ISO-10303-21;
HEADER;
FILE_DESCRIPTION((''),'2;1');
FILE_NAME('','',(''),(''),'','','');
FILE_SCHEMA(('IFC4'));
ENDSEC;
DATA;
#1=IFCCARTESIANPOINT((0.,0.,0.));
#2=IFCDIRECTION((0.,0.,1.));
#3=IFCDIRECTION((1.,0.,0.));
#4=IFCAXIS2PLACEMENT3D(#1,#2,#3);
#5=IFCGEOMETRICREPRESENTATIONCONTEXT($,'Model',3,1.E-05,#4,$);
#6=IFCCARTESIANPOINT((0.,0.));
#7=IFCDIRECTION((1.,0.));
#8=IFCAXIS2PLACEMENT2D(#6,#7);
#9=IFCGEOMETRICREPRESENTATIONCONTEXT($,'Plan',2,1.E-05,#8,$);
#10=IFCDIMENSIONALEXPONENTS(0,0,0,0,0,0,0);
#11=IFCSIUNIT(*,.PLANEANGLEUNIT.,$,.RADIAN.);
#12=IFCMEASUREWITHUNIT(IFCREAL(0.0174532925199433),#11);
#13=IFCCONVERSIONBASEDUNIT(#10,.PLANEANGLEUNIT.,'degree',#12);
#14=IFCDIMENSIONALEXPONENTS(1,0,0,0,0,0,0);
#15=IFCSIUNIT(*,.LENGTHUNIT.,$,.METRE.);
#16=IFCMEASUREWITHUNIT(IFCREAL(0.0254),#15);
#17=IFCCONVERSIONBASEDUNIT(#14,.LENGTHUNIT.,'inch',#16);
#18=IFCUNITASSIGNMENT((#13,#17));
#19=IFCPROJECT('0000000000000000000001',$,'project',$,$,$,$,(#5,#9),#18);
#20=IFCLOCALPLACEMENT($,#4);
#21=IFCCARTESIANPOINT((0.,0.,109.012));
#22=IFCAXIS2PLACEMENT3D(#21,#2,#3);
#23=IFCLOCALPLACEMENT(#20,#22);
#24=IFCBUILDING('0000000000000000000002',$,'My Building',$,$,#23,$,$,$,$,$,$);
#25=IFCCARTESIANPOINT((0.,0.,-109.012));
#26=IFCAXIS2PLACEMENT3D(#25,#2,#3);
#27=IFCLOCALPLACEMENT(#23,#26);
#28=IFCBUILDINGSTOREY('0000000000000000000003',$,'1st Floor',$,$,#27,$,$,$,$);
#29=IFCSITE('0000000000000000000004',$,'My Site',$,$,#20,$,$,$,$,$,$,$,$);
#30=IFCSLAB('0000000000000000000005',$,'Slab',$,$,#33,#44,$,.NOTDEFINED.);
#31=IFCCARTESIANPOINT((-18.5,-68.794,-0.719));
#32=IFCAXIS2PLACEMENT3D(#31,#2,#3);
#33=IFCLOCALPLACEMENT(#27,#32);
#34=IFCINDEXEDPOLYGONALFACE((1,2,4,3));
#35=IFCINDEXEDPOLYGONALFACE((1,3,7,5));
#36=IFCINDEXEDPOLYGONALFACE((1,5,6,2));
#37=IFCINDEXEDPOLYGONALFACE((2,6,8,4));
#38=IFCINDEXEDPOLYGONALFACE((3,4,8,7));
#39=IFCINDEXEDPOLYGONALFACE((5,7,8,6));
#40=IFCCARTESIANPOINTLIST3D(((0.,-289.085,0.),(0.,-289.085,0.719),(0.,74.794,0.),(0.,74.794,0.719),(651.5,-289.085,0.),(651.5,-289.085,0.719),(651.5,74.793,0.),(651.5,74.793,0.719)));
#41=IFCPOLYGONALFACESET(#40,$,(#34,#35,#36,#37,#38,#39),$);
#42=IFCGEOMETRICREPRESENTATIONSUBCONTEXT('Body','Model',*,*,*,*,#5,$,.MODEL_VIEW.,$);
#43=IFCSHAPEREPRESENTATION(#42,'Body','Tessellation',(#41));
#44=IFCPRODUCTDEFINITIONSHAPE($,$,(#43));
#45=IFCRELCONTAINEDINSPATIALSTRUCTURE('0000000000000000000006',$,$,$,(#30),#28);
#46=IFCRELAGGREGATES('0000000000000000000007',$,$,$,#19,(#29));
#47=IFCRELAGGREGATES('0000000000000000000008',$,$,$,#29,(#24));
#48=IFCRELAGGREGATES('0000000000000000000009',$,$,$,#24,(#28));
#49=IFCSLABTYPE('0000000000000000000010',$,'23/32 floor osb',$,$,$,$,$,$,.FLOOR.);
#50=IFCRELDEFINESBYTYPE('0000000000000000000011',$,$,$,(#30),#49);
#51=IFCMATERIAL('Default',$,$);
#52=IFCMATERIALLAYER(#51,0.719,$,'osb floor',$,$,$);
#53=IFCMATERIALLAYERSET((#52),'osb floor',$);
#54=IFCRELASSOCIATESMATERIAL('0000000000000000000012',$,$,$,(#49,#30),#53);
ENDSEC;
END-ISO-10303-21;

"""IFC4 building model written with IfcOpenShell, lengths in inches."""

from ifc_helpers import new_model, entity, si_unit, converted_unit, frame, origin_with_axes, origin_2d_with_axis, place, context, subcontext, project, spatial, line, indexed_curve, outline, extrude, material, layer, layer_set, layer_usage, type_object, element, save


model = new_model("IFC4")

# Units and contexts
model_context = context("Model", 3, precision=1e-05, world=origin_with_axes())
plan_context = context("Plan", 2, precision=1e-05, world=origin_2d_with_axis())
body_context = subcontext(model_context, "Body", "Model", "MODEL_VIEW")
ifc_project = project(units=[converted_unit("PLANEANGLEUNIT", "degree", entity("IfcReal", 0.0174532925199433), si_unit("PLANEANGLEUNIT", "RADIAN"), dimensions=[0, 0, 0, 0, 0, 0, 0]), converted_unit("LENGTHUNIT", "inch", entity("IfcReal", 0.0254), si_unit("LENGTHUNIT", "METRE"), dimensions=[1, 0, 0, 0, 0, 0, 0])], contexts=[model_context, plan_context])

# Site, building, storey
site_placement = place(None, origin_with_axes())
site = spatial("IfcSite", under=ifc_project, at=site_placement, Name="My Site")
building_placement = place(site_placement, frame((0.0, 0.0, 109.012), z_axis=(0.0, 0.0, 1.0), x_axis=(1.0, 0.0, 0.0)))
building = spatial("IfcBuilding", under=site, at=building_placement, Name="My Building")
storey_placement = place(building_placement, frame((0.0, 0.0, -109.012), z_axis=(0.0, 0.0, 1.0), x_axis=(1.0, 0.0, 0.0)))
storey = spatial("IfcBuildingStorey", under=building, at=storey_placement, Name="1st Floor")

# Shared definitions
ifc_material = material(Name="Default")

# Slab
ifc_layer_1 = layer(ifc_material, 0.719, Name="osb floor")
ifc_layer_set_1 = layer_set([ifc_layer_1], Name="osb floor")
ifc_layer_usage_1 = layer_usage(ifc_layer_set_1, "AXIS3", "POSITIVE", 0.0)
slab_type = type_object("IfcSlabType", Name="23/32 floor osb", PredefinedType="FLOOR", material=ifc_layer_set_1)
slab_placement = place(storey_placement, frame((-18.5, -68.794, -0.719), z_axis=(0.0, 0.0, 1.0), x_axis=(1.0, 0.0, 0.0)))
element("IfcSlab", 1, at=slab_placement, inside=storey, type_object=slab_type, material=ifc_layer_usage_1, Name="Slab", PredefinedType="NOTDEFINED", context=body_context, shape_type="SweptSolid", body=[
    extrude(outline(indexed_curve([(651.5, 74.793), (651.5, -289.085), (0.0, -289.085), (0.0, 74.794)], segments=[line(3, 2), line(2, 1), line(1, 4), line(4, 3)], self_intersect=False)), None, (0.0, 0.0, 1.0), 0.719),
])

save(model, "model.ifc")
